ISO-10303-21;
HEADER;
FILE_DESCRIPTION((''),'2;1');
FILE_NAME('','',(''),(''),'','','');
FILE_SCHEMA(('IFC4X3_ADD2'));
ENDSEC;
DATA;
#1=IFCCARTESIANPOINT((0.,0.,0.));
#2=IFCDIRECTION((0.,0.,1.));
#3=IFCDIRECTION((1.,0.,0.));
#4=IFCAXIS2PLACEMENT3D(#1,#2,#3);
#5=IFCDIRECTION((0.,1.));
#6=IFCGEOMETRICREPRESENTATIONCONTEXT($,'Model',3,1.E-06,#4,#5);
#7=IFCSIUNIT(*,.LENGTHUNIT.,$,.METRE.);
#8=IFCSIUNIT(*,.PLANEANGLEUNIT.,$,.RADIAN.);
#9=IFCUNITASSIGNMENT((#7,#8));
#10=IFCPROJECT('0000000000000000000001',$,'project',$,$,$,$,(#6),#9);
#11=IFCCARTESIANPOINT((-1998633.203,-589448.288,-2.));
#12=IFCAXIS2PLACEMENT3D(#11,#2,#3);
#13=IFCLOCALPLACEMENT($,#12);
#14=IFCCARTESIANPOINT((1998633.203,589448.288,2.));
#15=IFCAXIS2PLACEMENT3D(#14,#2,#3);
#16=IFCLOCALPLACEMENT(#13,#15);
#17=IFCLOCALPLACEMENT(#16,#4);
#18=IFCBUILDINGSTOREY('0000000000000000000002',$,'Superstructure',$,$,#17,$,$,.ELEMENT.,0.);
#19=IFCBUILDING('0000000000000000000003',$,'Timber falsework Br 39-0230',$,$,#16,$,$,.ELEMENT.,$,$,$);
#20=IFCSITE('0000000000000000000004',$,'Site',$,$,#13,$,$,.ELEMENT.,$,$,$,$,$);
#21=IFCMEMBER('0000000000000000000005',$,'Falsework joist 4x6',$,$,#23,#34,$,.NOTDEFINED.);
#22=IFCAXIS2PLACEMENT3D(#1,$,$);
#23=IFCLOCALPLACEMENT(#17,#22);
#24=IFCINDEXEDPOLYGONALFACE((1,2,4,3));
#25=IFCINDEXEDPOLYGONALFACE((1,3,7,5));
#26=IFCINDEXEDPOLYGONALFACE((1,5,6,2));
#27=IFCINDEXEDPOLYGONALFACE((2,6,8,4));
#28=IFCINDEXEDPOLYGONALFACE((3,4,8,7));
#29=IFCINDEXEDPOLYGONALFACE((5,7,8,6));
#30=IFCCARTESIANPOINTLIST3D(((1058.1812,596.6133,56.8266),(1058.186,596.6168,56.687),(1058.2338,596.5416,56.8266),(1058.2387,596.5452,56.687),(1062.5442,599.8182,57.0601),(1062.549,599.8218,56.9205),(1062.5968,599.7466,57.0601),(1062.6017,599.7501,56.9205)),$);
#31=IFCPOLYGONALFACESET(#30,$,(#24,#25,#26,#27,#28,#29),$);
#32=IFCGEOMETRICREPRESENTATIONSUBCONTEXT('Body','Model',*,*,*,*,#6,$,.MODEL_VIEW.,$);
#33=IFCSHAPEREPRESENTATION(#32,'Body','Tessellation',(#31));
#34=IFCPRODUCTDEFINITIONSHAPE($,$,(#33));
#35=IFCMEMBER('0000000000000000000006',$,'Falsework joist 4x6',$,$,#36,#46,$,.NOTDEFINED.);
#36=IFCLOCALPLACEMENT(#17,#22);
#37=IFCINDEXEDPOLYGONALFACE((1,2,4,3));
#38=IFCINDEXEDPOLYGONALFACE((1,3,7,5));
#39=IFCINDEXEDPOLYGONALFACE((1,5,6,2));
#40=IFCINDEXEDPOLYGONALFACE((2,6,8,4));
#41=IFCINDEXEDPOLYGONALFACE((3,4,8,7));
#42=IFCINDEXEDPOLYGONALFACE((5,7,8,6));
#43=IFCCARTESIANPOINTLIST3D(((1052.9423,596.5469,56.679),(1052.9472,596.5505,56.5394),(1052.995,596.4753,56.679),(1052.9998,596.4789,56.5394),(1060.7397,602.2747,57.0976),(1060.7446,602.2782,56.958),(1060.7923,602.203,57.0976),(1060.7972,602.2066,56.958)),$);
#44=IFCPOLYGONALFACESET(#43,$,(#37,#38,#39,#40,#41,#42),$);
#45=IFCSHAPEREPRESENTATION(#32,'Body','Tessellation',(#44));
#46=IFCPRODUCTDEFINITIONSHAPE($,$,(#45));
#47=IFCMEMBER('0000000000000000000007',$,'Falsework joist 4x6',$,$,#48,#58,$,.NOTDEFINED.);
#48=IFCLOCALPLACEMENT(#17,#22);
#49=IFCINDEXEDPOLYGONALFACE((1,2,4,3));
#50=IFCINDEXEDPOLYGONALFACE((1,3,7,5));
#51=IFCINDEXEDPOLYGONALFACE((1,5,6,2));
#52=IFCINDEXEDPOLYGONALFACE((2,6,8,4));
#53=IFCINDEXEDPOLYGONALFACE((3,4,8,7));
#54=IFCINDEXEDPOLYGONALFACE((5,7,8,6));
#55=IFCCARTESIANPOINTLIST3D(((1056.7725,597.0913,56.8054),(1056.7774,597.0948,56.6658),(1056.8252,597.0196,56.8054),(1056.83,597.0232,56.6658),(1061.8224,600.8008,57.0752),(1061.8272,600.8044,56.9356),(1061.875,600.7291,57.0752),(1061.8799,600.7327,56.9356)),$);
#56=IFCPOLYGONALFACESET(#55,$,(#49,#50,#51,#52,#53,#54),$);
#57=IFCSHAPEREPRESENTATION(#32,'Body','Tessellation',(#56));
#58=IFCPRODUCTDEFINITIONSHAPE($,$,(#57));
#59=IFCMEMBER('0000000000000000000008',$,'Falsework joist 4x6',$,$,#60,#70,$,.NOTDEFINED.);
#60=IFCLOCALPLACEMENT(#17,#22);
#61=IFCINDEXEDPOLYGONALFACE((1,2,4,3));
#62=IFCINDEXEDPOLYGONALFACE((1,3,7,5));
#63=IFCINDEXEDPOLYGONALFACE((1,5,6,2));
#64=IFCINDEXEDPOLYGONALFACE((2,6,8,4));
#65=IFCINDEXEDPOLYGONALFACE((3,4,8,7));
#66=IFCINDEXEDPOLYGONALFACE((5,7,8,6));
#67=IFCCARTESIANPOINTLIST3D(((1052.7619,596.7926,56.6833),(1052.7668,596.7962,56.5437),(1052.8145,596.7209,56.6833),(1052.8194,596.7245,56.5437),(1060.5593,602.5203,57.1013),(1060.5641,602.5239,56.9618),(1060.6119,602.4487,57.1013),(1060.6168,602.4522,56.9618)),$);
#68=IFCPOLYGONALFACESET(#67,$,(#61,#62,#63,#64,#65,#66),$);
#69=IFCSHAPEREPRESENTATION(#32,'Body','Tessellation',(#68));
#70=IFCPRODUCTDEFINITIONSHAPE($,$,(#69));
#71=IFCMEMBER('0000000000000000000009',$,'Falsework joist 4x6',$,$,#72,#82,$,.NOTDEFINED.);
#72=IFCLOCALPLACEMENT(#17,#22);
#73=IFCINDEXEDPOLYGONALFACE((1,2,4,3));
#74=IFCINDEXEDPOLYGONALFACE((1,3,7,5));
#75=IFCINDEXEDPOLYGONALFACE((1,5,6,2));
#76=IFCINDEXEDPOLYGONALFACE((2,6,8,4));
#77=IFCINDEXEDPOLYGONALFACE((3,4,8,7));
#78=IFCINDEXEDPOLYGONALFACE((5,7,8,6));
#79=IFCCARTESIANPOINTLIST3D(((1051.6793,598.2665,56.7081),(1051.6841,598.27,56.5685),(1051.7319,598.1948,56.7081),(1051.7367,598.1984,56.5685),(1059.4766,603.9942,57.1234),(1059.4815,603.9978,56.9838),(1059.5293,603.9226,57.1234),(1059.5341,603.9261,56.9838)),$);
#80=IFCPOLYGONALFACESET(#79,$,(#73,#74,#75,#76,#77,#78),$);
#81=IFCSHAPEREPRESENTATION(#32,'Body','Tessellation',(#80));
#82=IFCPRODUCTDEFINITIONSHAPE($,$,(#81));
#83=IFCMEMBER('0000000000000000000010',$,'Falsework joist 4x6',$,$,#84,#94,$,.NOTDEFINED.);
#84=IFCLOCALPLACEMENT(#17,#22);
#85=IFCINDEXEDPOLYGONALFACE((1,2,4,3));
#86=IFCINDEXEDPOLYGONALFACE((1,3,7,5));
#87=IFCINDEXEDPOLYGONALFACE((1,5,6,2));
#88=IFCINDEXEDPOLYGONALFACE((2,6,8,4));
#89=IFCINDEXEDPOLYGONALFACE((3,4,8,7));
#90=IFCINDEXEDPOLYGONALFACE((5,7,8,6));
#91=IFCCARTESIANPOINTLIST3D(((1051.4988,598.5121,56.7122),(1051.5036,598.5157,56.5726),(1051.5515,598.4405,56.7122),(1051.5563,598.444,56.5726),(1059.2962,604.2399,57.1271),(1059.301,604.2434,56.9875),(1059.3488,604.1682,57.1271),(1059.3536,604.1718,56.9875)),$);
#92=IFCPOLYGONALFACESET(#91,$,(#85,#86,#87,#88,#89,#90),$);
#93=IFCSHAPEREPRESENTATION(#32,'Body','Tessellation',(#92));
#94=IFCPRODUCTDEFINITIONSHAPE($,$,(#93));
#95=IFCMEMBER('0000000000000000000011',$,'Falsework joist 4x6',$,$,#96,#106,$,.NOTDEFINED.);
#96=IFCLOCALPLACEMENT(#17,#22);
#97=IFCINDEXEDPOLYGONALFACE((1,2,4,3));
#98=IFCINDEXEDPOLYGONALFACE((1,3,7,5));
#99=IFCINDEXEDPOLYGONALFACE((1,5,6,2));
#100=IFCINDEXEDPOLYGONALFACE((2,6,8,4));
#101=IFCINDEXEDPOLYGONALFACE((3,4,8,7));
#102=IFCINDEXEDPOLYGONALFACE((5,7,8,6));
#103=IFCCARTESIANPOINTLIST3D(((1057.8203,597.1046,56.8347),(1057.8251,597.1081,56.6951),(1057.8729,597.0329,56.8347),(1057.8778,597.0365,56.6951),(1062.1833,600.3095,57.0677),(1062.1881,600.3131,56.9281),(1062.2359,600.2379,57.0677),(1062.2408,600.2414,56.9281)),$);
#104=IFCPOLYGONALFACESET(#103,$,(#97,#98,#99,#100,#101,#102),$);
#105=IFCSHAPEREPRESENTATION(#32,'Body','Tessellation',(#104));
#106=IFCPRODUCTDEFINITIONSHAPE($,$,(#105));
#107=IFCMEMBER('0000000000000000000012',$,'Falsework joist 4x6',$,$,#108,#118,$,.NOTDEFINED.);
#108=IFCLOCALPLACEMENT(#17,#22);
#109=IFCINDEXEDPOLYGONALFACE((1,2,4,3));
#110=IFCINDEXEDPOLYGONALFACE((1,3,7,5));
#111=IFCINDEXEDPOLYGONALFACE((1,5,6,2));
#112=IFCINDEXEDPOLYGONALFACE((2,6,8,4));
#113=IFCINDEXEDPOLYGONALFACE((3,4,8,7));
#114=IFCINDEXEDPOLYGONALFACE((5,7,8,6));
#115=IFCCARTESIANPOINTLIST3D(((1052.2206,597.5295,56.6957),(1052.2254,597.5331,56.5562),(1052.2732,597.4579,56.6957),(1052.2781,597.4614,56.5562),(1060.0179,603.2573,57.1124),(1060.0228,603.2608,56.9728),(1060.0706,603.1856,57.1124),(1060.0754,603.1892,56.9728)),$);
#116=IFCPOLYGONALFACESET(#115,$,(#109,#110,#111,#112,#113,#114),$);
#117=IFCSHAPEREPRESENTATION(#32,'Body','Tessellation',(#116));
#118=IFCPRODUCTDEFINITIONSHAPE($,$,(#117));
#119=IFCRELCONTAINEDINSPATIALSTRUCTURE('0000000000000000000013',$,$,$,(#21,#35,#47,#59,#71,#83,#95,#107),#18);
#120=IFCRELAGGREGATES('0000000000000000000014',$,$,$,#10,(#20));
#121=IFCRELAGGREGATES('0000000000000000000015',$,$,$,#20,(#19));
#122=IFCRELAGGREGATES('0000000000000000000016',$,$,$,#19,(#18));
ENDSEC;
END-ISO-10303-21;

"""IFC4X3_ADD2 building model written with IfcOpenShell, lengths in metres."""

from ifc_helpers import new_model, si_unit, direction, frame, frame_2d, origin, origin_with_axes, place, context, subcontext, project, spatial, rectangle, extrude, element, save


model = new_model("IFC4X3_ADD2")

# Units and contexts
model_context = context("Model", 3, precision=1e-06, world=origin_with_axes(), true_north=direction((0.0, 1.0)))
body_context = subcontext(model_context, "Body", "Model", "MODEL_VIEW")
ifc_project = project(units=[si_unit("LENGTHUNIT", "METRE"), si_unit("PLANEANGLEUNIT", "RADIAN")], contexts=[model_context])

# Site, building, storey
site_placement = place(None, frame((-1998633.203, -589448.288, -2.0), z_axis=(0.0, 0.0, 1.0), x_axis=(1.0, 0.0, 0.0)))
site = spatial("IfcSite", under=ifc_project, at=site_placement, Name="Site", CompositionType="ELEMENT")
building_placement = place(site_placement, frame((1998633.203, 589448.288, 2.0), z_axis=(0.0, 0.0, 1.0), x_axis=(1.0, 0.0, 0.0)))
building = spatial("IfcBuilding", under=site, at=building_placement, Name="Timber falsework Br 39-0230", CompositionType="ELEMENT")
storey_placement = place(building_placement, origin_with_axes())
storey = spatial("IfcBuildingStorey", under=building, at=storey_placement, Name="Superstructure", CompositionType="ELEMENT", Elevation=0.0)

# Members
member_1_placement = place(storey_placement, frame((1058.2123, 596.581, 56.687), z_axis=(0.80518, 0.591463, 0.043092), x_axis=(-0.592013, 0.805928, 0.0)))
element("IfcMember", 1, at=member_1_placement, inside=storey, Name="Falsework joist 4x6", PredefinedType="NOTDEFINED", context=body_context, shape_type="SweptSolid", body=[
    extrude(rectangle(XDim=0.0889, YDim=0.1397, at=frame_2d((0.0, 0.0698))), origin(), (0.0, 0.0, 1.0), 5.4187),
])
member_2_placement = place(storey_placement, frame((1052.9735, 596.5147, 56.5394), z_axis=(0.805175, 0.59146, 0.043225), x_axis=(-0.592013, 0.805928, 0.0)))
element("IfcMember", 2, at=member_2_placement, inside=storey, Name="Falsework joist 4x6", PredefinedType="NOTDEFINED", context=body_context, shape_type="SweptSolid", body=[
    extrude(rectangle(XDim=0.0889, YDim=0.1397, at=frame_2d((0.0, 0.0698))), origin(), (0.0, 0.0, 1.0), 9.6841),
])
member_3_placement = place(storey_placement, frame((1056.8037, 597.059, 56.6658), z_axis=(0.805182, 0.591465, 0.043023), x_axis=(-0.592013, 0.805928, 0.0)))
element("IfcMember", 3, at=member_3_placement, inside=storey, Name="Falsework joist 4x6", PredefinedType="NOTDEFINED", context=body_context, shape_type="SweptSolid", body=[
    extrude(rectangle(XDim=0.0889, YDim=0.1397, at=frame_2d((0.0, 0.0698))), origin(), (0.0, 0.0, 1.0), 6.2717),
])
member_4_placement = place(storey_placement, frame((1052.7931, 596.7603, 56.5437), z_axis=(0.805177, 0.591461, 0.043166), x_axis=(-0.592013, 0.805928, 0.0)))
element("IfcMember", 4, at=member_4_placement, inside=storey, Name="Falsework joist 4x6", PredefinedType="NOTDEFINED", context=body_context, shape_type="SweptSolid", body=[
    extrude(rectangle(XDim=0.0889, YDim=0.1397, at=frame_2d((0.0, 0.0698))), origin(), (0.0, 0.0, 1.0), 9.684),
])
member_5_placement = place(storey_placement, frame((1051.7104, 598.2342, 56.5685), z_axis=(0.805187, 0.591469, 0.042885), x_axis=(-0.592013, 0.805928, 0.0)))
element("IfcMember", 5, at=member_5_placement, inside=storey, Name="Falsework joist 4x6", PredefinedType="NOTDEFINED", context=body_context, shape_type="SweptSolid", body=[
    extrude(rectangle(XDim=0.0889, YDim=0.1397, at=frame_2d((0.0, 0.0698))), origin(), (0.0, 0.0, 1.0), 9.6839),
])
member_6_placement = place(storey_placement, frame((1051.53, 598.4799, 56.5726), z_axis=(0.805188, 0.59147, 0.042838), x_axis=(-0.592013, 0.805928, 0.0)))
element("IfcMember", 6, at=member_6_placement, inside=storey, Name="Falsework joist 4x6", PredefinedType="NOTDEFINED", context=body_context, shape_type="SweptSolid", body=[
    extrude(rectangle(XDim=0.0889, YDim=0.1397, at=frame_2d((0.0, 0.0698))), origin(), (0.0, 0.0, 1.0), 9.6839),
])
member_7_placement = place(storey_placement, frame((1057.8514, 597.0723, 56.6951), z_axis=(0.805183, 0.591466, 0.042999), x_axis=(-0.592013, 0.805928, 0.0)))
element("IfcMember", 7, at=member_7_placement, inside=storey, Name="Falsework joist 4x6", PredefinedType="NOTDEFINED", context=body_context, shape_type="SweptSolid", body=[
    extrude(rectangle(XDim=0.0889, YDim=0.1397, at=frame_2d((0.0, 0.0698))), origin(), (0.0, 0.0, 1.0), 5.4186),
])
member_8_placement = place(storey_placement, frame((1052.2517, 597.4973, 56.5562), z_axis=(0.805182, 0.591465, 0.043026), x_axis=(-0.592013, 0.805928, 0.0)))
element("IfcMember", 8, at=member_8_placement, inside=storey, Name="Falsework joist 4x6", PredefinedType="NOTDEFINED", context=body_context, shape_type="SweptSolid", body=[
    extrude(rectangle(XDim=0.0889, YDim=0.1397, at=frame_2d((0.0, 0.0698))), origin(), (0.0, 0.0, 1.0), 9.684),
])

save(model, "model.ifc")
